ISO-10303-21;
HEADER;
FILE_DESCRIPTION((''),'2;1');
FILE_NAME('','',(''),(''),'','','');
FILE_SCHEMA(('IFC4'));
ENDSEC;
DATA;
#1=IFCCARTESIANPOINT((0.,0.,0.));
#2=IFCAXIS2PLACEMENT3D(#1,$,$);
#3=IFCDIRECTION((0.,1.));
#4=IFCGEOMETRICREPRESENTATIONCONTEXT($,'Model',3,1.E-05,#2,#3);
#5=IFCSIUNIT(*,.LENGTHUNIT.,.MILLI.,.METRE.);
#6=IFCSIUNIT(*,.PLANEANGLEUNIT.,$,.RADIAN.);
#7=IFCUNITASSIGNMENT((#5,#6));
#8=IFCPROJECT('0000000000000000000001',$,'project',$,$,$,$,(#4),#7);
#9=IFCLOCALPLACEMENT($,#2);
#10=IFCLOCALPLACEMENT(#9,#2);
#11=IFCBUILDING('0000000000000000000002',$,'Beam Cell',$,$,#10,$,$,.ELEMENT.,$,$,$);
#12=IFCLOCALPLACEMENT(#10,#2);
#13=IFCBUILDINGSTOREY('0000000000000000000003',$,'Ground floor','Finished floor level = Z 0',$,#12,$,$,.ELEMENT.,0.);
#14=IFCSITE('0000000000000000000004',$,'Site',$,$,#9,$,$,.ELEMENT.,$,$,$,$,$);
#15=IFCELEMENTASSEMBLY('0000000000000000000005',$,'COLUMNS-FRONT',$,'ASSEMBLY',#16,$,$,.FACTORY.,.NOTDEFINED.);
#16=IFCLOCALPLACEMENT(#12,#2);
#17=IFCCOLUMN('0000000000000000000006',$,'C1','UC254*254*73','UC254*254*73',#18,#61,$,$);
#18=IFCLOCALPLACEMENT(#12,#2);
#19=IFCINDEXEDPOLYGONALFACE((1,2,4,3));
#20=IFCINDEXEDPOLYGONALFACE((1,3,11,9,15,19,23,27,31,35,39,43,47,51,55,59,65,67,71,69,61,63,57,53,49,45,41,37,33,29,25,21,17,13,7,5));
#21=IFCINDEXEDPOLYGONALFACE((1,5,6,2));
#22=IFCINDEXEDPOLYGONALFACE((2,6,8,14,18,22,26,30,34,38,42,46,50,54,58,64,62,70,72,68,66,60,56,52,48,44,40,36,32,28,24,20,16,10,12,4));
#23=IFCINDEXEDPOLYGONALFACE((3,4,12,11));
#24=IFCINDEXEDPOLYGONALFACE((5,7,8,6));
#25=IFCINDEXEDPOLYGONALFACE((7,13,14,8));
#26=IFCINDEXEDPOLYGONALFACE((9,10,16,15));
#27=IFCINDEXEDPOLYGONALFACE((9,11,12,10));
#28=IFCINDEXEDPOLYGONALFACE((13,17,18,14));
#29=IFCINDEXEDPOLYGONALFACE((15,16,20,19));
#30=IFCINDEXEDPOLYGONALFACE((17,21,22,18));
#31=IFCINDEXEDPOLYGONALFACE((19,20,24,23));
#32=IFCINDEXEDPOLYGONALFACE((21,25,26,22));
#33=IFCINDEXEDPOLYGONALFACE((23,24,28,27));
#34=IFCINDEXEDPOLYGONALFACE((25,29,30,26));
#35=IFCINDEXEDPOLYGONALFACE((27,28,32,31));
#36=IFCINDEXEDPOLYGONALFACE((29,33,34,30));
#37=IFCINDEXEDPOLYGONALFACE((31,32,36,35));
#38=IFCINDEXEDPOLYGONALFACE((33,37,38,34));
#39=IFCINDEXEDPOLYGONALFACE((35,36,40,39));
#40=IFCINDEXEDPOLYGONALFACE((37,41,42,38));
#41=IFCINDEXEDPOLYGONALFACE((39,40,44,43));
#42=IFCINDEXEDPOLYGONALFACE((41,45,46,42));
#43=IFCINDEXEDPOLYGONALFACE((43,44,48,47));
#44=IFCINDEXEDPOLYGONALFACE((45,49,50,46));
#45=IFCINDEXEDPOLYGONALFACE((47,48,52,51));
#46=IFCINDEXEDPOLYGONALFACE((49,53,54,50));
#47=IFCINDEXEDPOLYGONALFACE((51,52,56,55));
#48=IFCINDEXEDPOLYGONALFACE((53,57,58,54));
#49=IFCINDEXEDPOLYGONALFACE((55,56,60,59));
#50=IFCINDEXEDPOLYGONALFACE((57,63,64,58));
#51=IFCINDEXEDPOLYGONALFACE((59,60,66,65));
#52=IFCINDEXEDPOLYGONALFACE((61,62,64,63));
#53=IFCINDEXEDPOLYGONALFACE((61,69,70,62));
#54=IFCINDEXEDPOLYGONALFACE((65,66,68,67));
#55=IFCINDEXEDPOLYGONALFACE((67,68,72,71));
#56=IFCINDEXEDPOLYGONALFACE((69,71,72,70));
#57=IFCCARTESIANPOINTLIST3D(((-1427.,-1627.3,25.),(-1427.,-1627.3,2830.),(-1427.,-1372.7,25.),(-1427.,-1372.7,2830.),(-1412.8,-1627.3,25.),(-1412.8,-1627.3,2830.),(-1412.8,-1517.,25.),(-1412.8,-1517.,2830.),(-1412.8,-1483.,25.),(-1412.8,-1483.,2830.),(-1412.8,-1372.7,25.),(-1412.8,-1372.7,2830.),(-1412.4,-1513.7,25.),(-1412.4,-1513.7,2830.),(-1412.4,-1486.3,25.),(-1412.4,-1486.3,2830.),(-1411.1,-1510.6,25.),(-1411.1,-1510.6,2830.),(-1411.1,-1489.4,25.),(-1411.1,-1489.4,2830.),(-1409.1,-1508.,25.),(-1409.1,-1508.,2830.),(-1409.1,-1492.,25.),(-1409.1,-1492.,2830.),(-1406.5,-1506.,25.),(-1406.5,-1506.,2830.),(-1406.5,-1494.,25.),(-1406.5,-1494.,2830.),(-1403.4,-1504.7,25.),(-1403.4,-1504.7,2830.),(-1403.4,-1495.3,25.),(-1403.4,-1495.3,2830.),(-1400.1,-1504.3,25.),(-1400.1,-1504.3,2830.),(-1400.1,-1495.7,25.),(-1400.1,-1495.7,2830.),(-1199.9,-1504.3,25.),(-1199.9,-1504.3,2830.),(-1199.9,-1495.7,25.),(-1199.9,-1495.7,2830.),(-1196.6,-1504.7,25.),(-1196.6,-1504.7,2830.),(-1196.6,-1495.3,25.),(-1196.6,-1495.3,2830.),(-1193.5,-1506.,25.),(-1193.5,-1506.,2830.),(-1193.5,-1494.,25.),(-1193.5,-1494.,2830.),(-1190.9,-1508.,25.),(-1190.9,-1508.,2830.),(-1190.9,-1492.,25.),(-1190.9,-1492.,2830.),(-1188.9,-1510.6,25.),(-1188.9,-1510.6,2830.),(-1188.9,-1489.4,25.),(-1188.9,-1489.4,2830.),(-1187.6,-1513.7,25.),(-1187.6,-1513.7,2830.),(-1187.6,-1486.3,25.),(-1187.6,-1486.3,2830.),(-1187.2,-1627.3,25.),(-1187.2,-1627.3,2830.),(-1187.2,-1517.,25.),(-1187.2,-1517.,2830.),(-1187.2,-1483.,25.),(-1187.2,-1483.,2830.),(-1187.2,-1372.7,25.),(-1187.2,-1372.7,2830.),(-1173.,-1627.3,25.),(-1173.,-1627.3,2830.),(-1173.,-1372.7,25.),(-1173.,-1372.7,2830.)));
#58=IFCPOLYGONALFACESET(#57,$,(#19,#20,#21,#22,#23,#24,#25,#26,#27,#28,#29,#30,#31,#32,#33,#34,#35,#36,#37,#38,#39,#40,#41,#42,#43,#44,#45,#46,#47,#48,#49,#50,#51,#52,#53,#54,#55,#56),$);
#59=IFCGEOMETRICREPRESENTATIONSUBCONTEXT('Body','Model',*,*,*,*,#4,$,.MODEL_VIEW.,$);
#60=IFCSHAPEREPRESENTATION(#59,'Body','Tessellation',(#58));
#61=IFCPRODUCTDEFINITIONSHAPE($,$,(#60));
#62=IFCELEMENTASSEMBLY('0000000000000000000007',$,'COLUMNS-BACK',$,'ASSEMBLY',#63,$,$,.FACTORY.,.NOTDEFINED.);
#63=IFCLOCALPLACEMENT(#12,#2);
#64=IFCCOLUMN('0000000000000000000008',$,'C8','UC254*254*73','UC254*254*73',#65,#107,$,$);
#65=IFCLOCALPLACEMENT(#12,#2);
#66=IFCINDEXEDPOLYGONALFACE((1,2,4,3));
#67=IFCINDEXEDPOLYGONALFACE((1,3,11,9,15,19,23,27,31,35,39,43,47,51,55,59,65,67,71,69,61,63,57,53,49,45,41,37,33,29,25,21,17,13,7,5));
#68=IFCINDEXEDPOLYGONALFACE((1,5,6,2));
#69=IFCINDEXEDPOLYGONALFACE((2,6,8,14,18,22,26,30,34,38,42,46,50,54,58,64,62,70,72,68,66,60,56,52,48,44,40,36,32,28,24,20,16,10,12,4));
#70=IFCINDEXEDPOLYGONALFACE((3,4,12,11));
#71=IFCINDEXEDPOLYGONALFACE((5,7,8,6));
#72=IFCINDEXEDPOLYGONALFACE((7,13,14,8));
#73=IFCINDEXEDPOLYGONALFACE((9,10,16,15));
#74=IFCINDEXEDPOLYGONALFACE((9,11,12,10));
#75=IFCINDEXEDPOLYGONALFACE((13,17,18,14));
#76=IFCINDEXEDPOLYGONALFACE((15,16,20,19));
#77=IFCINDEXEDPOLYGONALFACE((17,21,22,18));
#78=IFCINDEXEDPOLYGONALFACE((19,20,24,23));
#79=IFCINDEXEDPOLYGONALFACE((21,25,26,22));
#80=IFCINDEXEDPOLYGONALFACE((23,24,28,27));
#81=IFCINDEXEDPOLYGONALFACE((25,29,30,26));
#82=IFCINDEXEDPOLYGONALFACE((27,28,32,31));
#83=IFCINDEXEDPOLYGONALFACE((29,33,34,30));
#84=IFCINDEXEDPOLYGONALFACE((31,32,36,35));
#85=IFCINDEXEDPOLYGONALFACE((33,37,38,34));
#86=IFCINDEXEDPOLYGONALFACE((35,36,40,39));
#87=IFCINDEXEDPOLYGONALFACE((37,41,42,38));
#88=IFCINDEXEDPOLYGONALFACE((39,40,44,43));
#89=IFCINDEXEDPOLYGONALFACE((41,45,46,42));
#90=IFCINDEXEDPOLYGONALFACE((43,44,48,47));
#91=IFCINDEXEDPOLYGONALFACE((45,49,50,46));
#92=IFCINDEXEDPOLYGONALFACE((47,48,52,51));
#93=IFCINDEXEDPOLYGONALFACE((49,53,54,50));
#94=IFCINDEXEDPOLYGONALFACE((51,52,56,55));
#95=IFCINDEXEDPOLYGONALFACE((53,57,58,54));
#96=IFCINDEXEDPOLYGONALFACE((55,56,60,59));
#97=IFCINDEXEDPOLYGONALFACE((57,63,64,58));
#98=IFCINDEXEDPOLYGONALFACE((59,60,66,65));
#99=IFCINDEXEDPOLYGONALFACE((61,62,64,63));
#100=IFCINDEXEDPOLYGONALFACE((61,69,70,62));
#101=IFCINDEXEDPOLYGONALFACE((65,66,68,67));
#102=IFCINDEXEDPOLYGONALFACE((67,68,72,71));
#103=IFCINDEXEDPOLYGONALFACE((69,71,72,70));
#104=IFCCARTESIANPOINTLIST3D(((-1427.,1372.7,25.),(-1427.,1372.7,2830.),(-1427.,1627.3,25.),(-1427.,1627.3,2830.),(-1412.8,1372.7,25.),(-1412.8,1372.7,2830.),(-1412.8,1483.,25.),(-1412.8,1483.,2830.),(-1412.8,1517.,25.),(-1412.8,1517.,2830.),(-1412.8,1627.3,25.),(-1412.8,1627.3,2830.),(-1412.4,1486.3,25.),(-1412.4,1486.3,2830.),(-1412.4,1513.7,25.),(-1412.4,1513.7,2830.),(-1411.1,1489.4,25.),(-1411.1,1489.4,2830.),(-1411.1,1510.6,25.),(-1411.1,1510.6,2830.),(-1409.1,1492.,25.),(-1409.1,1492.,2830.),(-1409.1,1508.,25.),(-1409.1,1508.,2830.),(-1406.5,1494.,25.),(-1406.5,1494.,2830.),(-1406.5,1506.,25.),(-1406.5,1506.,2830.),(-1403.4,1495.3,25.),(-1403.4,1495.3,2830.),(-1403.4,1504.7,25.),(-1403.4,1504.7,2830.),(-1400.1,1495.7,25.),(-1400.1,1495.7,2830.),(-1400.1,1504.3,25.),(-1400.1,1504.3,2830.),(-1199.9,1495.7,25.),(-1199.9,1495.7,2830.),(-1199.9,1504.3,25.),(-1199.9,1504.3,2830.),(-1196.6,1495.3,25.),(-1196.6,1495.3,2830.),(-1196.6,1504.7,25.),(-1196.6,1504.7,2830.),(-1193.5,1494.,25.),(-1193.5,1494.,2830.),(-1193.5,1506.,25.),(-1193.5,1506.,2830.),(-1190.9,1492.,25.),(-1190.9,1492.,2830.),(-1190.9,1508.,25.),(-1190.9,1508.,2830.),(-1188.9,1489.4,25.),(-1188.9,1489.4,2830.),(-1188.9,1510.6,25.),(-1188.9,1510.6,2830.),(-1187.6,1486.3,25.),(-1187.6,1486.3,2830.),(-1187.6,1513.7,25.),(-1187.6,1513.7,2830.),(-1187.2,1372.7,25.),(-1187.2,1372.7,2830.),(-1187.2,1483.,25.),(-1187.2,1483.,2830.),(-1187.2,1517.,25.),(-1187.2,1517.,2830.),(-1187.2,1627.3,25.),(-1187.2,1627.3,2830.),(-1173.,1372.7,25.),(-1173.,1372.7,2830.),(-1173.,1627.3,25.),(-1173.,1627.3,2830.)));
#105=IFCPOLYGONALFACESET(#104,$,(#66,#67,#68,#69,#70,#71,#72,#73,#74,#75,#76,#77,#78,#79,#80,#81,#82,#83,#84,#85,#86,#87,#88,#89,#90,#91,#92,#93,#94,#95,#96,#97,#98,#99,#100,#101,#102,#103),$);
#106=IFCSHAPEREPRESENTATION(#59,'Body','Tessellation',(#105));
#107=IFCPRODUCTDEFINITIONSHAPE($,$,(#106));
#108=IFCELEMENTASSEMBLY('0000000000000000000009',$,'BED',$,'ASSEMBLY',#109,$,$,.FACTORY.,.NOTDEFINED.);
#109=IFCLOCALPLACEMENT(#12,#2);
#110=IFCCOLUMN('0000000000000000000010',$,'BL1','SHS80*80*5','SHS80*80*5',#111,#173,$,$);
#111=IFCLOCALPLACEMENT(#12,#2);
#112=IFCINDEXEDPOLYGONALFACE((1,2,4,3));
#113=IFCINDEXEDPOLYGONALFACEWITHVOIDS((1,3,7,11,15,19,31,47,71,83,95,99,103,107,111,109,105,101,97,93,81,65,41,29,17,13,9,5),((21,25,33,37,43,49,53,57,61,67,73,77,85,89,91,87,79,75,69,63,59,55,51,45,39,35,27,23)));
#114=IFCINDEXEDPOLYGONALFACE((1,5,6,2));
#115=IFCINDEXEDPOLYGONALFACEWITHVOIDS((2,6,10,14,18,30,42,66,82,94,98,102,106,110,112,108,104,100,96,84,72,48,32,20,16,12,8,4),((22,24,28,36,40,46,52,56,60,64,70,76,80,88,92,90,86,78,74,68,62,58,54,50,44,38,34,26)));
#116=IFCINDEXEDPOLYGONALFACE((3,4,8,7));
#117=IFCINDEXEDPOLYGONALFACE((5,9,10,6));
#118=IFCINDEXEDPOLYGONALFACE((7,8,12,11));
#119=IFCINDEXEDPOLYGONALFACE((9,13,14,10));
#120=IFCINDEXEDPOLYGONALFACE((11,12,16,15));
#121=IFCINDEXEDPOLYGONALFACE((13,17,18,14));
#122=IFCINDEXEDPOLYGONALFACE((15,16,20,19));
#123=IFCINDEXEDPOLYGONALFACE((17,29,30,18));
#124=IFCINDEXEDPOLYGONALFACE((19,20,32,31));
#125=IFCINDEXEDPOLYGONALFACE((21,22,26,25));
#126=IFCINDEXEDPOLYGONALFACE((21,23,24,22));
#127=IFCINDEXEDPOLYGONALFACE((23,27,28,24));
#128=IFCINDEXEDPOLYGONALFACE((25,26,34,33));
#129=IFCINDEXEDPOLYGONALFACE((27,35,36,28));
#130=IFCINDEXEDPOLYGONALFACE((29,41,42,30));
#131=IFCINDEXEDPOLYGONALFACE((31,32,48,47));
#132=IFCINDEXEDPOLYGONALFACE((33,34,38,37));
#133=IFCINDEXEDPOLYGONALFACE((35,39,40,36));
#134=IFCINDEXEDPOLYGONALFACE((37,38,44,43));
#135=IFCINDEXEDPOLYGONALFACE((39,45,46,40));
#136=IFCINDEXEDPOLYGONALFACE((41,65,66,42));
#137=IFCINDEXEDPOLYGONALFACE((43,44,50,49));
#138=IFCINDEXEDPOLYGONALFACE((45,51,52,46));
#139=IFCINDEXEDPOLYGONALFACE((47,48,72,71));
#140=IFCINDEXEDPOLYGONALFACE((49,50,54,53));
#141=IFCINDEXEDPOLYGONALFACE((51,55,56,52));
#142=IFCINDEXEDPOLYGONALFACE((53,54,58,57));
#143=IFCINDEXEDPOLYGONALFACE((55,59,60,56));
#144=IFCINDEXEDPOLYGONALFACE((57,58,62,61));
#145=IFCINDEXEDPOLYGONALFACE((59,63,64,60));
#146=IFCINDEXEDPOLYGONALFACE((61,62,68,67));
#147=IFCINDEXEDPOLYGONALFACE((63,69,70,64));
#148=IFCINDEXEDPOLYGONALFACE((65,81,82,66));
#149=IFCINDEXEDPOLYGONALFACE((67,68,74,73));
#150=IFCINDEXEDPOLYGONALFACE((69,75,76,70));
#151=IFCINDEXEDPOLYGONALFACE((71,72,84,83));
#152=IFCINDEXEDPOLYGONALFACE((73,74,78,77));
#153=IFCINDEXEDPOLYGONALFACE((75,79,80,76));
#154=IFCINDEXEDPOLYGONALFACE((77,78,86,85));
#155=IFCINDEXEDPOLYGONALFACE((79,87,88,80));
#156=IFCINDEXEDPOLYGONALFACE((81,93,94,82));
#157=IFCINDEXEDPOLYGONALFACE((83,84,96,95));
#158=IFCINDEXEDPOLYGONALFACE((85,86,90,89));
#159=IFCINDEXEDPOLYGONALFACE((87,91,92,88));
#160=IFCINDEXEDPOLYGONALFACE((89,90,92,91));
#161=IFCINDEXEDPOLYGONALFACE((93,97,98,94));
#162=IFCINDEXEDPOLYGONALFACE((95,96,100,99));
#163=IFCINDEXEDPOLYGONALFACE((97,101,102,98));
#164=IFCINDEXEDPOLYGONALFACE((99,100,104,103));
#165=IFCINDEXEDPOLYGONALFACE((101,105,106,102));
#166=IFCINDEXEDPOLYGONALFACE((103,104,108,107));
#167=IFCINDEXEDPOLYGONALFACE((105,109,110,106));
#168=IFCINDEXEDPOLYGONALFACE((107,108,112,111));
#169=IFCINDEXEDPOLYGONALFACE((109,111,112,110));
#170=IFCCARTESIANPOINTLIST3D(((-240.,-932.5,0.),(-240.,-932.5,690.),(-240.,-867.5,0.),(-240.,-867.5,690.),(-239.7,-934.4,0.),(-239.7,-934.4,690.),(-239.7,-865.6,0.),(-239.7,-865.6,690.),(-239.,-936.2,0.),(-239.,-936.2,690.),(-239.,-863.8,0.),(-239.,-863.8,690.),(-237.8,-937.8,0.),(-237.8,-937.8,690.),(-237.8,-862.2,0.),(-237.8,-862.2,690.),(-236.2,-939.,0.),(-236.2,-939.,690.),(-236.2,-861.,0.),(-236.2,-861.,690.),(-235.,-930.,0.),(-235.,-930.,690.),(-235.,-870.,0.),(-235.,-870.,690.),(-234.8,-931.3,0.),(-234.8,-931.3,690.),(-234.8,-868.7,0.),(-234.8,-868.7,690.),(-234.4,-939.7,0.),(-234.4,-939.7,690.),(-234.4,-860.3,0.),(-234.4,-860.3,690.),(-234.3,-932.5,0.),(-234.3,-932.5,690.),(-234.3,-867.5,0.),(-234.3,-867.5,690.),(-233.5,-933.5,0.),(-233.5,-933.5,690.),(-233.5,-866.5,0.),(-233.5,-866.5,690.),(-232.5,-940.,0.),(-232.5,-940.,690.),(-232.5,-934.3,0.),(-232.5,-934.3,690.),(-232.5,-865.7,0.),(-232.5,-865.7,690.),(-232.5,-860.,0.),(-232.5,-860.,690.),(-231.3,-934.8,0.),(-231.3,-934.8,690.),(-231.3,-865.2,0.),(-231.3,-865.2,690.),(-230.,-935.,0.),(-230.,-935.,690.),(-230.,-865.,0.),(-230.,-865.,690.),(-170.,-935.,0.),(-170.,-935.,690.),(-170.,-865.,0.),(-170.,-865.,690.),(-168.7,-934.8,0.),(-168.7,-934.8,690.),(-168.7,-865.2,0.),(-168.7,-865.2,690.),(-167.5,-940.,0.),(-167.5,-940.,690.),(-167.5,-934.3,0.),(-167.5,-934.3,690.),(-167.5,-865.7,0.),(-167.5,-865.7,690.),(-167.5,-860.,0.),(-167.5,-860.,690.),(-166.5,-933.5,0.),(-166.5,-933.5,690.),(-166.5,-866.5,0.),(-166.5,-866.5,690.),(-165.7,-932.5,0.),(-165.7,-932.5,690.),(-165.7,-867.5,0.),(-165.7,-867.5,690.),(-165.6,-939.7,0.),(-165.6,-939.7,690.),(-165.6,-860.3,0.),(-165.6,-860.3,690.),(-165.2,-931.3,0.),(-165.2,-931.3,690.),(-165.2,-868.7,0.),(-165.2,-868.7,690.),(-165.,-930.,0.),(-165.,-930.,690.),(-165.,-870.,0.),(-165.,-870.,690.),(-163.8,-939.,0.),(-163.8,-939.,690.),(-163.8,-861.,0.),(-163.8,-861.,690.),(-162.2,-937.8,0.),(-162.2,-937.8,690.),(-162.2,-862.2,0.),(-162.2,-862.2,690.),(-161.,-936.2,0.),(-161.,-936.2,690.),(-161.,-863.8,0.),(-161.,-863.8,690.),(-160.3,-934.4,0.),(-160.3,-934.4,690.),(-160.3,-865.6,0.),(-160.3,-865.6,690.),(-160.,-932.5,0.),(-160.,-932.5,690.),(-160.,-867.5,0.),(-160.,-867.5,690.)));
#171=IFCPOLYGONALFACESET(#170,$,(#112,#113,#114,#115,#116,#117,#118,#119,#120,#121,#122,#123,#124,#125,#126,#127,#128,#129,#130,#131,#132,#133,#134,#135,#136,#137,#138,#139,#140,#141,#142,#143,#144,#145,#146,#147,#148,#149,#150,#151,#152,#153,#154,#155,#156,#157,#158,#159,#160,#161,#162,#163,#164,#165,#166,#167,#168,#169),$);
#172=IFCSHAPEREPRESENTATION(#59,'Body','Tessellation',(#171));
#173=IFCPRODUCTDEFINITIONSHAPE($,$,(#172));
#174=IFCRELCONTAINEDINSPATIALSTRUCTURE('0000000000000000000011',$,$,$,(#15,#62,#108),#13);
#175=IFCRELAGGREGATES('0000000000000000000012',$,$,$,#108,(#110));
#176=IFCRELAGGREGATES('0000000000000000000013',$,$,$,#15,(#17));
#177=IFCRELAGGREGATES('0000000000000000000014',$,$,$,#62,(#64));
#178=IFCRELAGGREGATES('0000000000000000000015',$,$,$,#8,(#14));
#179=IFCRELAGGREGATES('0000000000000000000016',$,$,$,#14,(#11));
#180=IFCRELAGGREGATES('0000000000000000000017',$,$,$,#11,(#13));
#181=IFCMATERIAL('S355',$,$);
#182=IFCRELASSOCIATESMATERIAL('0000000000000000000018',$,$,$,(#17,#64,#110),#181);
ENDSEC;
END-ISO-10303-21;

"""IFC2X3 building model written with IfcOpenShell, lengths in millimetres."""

from ifc_helpers import new_model, si_unit, direction, frame, origin, origin_2d, place, context, subcontext, project, spatial, hollow_rectangle, i_section, extrude, material, element, aggregate, save


model = new_model("IFC2X3")

# Units and contexts
model_context = context("Model", 3, precision=1e-05, world=origin(), true_north=direction((0.0, 1.0)))
body_context = subcontext(model_context, "Body", "Model", "MODEL_VIEW")
ifc_project = project(units=[si_unit("LENGTHUNIT", "METRE", prefix="MILLI"), si_unit("PLANEANGLEUNIT", "RADIAN")], contexts=[model_context])

# Site, building, storey
site_placement = place(None, origin())
site = spatial("IfcSite", under=ifc_project, at=site_placement, Name="Site", CompositionType="ELEMENT")
building_placement = place(site_placement, origin())
building = spatial("IfcBuilding", under=site, at=building_placement, Name="Beam Cell", CompositionType="ELEMENT")
storey_placement = place(building_placement, origin())
storey = spatial("IfcBuildingStorey", under=building, at=storey_placement, Name="Ground floor", Description="Finished floor level = Z 0", CompositionType="ELEMENT", Elevation=0.0)

# Element assemblies, columns
assembly_1_placement = place(storey_placement, origin())
assembly_1 = element("IfcElementAssembly", 1, at=assembly_1_placement, inside=storey, Name="COLUMNS-FRONT", ObjectType="ASSEMBLY", AssemblyPlace="FACTORY", PredefinedType="NOTDEFINED")
ifc_material = material(Name="S355")
column_1_placement = place(storey_placement, frame((-1300.0, -1500.0, 25.0), z_axis=(0.0, 0.0, 1.0), x_axis=(0.0, 1.0, 0.0)))
column_1 = element("IfcColumn", 2, at=column_1_placement, material=ifc_material, Name="C1", Description="UC254*254*73", ObjectType="UC254*254*73", context=body_context, shape_type="SweptSolid", body=[
    extrude(i_section(OverallWidth=254.6, OverallDepth=254.1, WebThickness=8.6, FlangeThickness=14.2, FilletRadius=12.7, at=origin_2d()), origin(), (0.0, 0.0, 1.0), 2805.0),
])
assembly_2_placement = place(storey_placement, origin())
assembly_2 = element("IfcElementAssembly", 3, at=assembly_2_placement, inside=storey, Name="COLUMNS-BACK", ObjectType="ASSEMBLY", AssemblyPlace="FACTORY", PredefinedType="NOTDEFINED")
column_2_placement = place(storey_placement, frame((-1300.0, 1500.0, 25.0), z_axis=(0.0, 0.0, 1.0), x_axis=(0.0, 1.0, 0.0)))
column_2 = element("IfcColumn", 4, at=column_2_placement, material=ifc_material, Name="C8", Description="UC254*254*73", ObjectType="UC254*254*73", context=body_context, shape_type="SweptSolid", body=[
    extrude(i_section(OverallWidth=254.6, OverallDepth=254.1, WebThickness=8.6, FlangeThickness=14.2, FilletRadius=12.7, at=origin_2d()), origin(), (0.0, 0.0, 1.0), 2805.0),
])

# Element assembly, column
assembly_3_placement = place(storey_placement, origin())
assembly_3 = element("IfcElementAssembly", 5, at=assembly_3_placement, inside=storey, Name="BED", ObjectType="ASSEMBLY", AssemblyPlace="FACTORY", PredefinedType="NOTDEFINED")
column_3_placement = place(storey_placement, frame((-200.0, -900.0, 0.0), z_axis=(0.0, 0.0, 1.0), x_axis=(1.0, 0.0, 0.0)))
column_3 = element("IfcColumn", 6, at=column_3_placement, material=ifc_material, Name="BL1", Description="SHS80*80*5", ObjectType="SHS80*80*5", context=body_context, shape_type="SweptSolid", body=[
    extrude(hollow_rectangle(XDim=80.0, YDim=80.0, WallThickness=5.0, InnerFilletRadius=5.0, OuterFilletRadius=7.5, at=origin_2d()), origin(), (0.0, 0.0, 1.0), 690.0),
])

aggregate(assembly_3, [column_3])

aggregate(assembly_1, [column_1])
aggregate(assembly_2, [column_2])

save(model, "model.ifc")
